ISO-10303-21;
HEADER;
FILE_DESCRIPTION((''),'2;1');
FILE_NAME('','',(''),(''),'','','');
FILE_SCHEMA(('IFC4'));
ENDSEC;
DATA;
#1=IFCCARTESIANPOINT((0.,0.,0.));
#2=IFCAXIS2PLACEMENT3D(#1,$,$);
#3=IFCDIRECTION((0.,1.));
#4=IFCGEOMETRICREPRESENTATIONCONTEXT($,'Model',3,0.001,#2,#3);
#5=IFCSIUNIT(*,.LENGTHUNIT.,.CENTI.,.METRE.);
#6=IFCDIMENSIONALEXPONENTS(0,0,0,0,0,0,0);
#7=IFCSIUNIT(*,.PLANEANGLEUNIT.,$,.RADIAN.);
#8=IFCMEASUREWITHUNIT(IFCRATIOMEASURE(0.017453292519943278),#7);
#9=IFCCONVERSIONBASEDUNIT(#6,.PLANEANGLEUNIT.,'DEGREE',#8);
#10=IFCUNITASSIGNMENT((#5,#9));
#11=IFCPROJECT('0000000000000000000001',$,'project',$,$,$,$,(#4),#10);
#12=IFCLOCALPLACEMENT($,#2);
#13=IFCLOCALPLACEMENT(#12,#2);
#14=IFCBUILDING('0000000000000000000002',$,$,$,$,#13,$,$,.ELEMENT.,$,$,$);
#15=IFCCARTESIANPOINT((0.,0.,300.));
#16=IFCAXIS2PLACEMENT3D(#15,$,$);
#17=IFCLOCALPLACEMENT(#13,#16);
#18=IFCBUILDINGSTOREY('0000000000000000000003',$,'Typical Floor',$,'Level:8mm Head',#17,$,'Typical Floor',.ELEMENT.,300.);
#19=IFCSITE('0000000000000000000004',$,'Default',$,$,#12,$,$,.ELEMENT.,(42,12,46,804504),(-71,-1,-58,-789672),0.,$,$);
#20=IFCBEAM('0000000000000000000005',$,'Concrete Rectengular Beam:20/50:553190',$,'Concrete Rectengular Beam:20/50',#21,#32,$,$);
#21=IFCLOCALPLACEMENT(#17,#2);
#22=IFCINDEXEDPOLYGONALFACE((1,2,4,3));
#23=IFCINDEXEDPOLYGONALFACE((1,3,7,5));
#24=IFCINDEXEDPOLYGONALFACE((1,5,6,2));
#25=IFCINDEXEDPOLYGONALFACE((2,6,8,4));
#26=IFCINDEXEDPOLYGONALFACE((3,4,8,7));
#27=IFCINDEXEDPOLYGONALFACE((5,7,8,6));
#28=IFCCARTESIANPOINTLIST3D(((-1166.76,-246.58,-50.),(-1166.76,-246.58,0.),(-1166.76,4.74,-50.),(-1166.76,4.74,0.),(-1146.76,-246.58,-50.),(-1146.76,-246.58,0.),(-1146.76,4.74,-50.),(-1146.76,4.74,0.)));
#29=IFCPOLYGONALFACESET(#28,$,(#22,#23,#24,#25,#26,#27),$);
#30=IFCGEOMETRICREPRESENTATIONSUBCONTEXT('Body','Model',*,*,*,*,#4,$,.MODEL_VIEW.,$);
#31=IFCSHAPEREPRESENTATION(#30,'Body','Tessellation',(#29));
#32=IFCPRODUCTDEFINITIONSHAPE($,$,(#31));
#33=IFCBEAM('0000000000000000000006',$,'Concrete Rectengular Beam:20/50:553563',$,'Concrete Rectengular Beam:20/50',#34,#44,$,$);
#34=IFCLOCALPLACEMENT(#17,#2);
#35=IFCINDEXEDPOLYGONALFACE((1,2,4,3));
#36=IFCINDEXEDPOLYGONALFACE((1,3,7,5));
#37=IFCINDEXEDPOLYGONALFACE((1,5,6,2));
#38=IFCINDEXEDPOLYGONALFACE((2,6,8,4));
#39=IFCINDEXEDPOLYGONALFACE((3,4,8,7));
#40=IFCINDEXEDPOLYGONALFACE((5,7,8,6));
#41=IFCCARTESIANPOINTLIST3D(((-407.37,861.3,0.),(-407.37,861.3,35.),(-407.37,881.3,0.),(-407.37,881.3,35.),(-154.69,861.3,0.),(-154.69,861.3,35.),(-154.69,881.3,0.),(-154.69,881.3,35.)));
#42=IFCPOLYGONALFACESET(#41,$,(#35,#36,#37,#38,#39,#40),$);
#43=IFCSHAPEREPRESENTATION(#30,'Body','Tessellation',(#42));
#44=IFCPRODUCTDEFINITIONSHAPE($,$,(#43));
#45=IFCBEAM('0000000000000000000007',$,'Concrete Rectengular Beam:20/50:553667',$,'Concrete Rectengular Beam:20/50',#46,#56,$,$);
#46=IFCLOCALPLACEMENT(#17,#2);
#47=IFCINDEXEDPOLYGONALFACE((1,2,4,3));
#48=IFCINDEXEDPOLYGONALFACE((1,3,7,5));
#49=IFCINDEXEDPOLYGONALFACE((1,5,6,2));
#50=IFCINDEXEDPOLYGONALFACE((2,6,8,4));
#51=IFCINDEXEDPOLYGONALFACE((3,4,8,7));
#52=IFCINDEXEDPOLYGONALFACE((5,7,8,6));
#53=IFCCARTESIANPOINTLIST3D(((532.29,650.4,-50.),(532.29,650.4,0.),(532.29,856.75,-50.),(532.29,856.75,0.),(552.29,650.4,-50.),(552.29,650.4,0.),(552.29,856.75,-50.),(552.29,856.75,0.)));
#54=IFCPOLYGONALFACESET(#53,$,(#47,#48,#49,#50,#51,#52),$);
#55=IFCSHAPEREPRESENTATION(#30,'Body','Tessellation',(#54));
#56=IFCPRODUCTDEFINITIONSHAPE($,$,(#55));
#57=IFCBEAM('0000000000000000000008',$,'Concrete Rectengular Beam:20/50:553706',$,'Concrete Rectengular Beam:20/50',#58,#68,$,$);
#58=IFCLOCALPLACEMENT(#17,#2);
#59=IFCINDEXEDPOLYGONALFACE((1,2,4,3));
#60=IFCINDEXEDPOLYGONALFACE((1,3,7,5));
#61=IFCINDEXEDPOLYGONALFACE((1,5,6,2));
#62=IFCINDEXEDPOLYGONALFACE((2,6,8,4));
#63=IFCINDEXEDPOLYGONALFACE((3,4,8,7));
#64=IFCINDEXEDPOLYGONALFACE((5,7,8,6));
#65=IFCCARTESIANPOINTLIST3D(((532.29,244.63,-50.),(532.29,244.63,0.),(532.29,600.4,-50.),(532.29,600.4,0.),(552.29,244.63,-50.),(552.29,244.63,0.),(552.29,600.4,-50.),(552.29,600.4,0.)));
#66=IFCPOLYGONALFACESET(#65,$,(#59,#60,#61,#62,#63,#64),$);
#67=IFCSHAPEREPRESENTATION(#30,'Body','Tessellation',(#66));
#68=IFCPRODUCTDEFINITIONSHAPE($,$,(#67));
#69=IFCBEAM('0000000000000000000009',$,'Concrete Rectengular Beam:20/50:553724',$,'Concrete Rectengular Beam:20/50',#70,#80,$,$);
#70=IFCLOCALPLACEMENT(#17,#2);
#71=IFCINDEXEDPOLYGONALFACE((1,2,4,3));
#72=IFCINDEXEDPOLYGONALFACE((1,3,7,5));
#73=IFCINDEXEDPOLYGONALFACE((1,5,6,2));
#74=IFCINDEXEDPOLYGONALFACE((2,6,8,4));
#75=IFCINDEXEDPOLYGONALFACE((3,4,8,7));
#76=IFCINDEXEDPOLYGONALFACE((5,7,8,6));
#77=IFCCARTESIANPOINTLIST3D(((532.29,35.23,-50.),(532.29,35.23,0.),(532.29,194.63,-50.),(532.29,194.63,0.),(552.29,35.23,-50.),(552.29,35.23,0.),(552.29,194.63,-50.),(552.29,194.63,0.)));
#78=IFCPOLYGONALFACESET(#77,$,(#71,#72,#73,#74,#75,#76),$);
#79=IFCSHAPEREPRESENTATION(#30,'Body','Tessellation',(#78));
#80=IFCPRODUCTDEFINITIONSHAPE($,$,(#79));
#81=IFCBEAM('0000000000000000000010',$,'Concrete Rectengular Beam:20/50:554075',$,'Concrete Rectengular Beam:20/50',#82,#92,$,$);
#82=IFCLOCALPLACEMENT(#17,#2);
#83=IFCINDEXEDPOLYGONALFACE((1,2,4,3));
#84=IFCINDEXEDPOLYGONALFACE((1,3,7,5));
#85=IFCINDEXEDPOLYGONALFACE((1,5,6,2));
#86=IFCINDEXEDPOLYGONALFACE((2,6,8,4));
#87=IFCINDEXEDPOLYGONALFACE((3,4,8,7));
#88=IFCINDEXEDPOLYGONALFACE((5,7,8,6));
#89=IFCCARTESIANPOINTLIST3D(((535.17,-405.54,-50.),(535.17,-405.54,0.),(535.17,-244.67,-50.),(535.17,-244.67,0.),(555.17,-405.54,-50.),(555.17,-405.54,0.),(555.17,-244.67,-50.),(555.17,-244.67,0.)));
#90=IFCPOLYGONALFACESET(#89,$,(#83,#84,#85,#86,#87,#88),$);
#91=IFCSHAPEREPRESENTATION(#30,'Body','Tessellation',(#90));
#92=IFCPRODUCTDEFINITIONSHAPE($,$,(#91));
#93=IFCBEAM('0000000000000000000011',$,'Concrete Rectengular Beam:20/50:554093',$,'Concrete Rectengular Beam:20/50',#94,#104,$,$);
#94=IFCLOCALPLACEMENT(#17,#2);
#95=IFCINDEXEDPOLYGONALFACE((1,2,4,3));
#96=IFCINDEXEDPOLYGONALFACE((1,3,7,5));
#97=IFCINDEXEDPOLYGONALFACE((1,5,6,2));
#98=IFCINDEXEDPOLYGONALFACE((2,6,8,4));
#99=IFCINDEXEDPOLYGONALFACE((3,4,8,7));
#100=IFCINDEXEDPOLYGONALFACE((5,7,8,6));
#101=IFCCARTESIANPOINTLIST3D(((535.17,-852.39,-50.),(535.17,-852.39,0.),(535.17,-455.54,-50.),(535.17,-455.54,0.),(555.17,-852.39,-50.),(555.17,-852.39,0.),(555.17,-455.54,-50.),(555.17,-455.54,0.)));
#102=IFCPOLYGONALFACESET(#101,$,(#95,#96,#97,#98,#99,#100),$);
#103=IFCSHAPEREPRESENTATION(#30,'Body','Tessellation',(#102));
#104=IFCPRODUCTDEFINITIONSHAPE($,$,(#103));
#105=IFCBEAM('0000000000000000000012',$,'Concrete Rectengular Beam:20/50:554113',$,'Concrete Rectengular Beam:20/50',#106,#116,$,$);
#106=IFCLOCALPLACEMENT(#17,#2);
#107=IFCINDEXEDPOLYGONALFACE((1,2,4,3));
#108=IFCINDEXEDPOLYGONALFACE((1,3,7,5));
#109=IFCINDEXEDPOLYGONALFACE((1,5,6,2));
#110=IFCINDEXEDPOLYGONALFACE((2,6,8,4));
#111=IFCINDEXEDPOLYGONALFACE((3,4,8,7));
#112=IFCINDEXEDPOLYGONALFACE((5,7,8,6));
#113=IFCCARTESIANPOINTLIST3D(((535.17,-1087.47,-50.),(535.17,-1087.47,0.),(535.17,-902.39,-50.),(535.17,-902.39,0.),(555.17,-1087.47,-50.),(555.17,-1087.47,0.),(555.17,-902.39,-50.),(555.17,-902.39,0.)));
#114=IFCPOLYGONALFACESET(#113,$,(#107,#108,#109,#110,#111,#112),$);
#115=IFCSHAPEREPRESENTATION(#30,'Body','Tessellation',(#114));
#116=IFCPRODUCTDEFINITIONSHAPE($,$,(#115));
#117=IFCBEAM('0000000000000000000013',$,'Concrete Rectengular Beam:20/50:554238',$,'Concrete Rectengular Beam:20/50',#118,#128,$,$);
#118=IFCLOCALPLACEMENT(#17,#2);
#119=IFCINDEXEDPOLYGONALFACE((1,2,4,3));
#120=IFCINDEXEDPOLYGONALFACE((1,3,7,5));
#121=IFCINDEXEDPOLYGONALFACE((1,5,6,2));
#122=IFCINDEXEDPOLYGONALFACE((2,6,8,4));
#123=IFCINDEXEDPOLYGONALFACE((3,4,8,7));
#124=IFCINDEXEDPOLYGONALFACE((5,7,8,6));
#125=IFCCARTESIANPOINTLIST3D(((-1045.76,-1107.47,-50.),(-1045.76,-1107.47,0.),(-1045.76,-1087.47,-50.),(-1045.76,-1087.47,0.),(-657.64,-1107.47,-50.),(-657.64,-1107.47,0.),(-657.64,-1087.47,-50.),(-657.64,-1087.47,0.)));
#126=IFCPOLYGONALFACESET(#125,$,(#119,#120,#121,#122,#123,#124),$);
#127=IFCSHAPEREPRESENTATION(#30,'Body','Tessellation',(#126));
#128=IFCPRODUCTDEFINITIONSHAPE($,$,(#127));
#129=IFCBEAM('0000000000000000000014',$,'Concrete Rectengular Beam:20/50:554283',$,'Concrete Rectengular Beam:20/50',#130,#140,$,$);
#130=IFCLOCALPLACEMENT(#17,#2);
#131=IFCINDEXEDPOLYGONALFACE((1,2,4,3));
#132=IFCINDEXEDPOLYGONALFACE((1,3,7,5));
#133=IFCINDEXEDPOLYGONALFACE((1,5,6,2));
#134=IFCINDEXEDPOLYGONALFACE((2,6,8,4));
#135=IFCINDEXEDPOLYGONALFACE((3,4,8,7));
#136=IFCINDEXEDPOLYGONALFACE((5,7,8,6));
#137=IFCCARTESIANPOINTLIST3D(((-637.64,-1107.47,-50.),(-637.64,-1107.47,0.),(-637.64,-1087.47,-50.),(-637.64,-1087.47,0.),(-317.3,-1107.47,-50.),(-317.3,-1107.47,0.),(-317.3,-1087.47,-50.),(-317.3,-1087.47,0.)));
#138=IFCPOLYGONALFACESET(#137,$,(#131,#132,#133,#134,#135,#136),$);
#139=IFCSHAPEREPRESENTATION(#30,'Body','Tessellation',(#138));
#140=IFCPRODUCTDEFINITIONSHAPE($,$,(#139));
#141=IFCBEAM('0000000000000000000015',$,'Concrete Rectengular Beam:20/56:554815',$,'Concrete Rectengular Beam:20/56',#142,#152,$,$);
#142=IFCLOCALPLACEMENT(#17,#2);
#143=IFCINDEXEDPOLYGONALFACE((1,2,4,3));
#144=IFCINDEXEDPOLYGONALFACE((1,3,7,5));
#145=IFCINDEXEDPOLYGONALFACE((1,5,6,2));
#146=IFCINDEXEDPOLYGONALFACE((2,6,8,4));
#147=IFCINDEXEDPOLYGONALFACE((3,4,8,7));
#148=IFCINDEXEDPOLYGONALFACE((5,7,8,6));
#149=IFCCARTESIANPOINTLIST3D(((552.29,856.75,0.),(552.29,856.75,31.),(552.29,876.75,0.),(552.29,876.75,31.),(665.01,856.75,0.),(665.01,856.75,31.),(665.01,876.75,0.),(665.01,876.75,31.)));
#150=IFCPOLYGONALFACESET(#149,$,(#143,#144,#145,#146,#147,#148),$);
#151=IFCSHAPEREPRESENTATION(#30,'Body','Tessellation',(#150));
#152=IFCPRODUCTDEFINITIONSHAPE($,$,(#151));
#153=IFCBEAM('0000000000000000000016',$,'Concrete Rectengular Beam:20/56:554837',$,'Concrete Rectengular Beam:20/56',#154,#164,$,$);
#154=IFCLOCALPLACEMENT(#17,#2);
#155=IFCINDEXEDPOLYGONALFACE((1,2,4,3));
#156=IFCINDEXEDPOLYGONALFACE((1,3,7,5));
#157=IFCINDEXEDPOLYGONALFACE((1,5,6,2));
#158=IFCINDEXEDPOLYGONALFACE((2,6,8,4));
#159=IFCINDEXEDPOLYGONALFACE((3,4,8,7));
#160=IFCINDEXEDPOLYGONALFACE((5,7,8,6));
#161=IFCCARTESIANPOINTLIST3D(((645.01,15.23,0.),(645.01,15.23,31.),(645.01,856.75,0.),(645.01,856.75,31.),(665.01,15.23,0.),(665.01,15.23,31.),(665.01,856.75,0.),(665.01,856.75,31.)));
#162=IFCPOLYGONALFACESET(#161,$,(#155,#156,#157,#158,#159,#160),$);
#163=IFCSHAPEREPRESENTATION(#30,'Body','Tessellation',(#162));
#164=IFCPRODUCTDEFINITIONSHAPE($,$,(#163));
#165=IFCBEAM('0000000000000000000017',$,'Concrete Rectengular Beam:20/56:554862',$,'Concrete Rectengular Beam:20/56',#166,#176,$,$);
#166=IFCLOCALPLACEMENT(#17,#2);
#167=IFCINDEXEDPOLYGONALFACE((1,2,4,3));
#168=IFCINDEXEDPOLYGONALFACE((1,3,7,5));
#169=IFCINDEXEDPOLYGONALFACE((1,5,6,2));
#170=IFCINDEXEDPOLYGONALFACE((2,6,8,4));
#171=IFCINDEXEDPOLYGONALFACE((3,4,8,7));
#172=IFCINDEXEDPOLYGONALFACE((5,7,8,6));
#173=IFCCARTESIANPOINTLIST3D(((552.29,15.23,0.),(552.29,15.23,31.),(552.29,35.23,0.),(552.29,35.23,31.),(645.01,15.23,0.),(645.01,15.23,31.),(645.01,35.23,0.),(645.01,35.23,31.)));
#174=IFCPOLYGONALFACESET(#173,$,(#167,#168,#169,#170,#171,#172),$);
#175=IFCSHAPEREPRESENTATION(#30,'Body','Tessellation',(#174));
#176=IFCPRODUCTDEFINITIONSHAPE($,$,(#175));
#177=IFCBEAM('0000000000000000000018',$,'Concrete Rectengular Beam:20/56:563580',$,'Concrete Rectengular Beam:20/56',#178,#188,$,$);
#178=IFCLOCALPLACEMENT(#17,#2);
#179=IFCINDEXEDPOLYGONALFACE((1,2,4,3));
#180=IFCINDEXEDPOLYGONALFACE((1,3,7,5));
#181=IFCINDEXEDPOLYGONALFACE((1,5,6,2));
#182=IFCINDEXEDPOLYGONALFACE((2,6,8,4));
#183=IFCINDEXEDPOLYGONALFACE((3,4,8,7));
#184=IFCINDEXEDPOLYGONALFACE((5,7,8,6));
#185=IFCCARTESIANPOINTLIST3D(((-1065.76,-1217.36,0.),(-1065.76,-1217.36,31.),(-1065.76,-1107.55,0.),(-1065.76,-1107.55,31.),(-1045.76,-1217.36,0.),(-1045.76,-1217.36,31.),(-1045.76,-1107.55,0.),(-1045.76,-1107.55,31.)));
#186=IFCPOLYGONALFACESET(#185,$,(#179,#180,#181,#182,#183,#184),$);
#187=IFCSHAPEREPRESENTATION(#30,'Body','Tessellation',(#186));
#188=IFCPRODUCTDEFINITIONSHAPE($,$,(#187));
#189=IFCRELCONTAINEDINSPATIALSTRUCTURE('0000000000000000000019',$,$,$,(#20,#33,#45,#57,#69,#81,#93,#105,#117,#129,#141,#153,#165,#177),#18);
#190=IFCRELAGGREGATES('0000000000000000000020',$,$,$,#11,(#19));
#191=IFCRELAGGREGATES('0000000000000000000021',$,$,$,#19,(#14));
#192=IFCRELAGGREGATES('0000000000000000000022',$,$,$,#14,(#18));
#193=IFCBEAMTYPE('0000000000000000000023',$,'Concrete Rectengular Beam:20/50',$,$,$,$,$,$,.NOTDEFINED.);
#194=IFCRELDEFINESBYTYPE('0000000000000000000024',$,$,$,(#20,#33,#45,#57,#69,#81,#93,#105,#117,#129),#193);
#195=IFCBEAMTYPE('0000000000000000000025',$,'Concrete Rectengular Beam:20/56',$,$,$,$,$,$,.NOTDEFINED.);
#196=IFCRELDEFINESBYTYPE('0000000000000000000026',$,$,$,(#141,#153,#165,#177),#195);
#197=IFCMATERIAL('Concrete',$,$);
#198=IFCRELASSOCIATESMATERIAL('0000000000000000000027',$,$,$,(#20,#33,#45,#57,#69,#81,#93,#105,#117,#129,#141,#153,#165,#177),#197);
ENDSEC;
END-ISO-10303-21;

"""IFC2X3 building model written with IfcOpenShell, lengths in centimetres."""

from ifc_helpers import new_model, entity, si_unit, converted_unit, direction, frame, frame_2d, origin, origin_2d_with_axis, place, context, subcontext, project, spatial, rectangle, extrude, material, type_object, element, save


model = new_model("IFC2X3")

# Units and contexts
model_context = context("Model", 3, precision=0.001, world=origin(), true_north=direction((0.0, 1.0)))
body_context = subcontext(model_context, "Body", "Model", "MODEL_VIEW")
ifc_project = project(units=[si_unit("LENGTHUNIT", "METRE", prefix="CENTI"), converted_unit("PLANEANGLEUNIT", "DEGREE", entity("IfcRatioMeasure", 0.017453292519943278), si_unit("PLANEANGLEUNIT", "RADIAN"), dimensions=[0, 0, 0, 0, 0, 0, 0])], contexts=[model_context])

# Site, building, storey
site_placement = place(None, origin())
site = spatial("IfcSite", under=ifc_project, at=site_placement, Name="Default", CompositionType="ELEMENT", RefLatitude=(42, 12, 46, 804504), RefLongitude=(-71, -1, -58, -789672), RefElevation=0.0)
building_placement = place(site_placement, origin())
building = spatial("IfcBuilding", under=site, at=building_placement, CompositionType="ELEMENT")
storey_placement = place(building_placement, frame((0.0, 0.0, 300.0)))
storey = spatial("IfcBuildingStorey", under=building, at=storey_placement, Name="Typical Floor", ObjectType="Level:8mm Head", LongName="Typical Floor", CompositionType="ELEMENT", Elevation=300.0)

# Beams
ifc_material = material(Name="Concrete")
beam_type_1 = type_object("IfcBeamType", Name="Concrete Rectengular Beam:20/50", PredefinedType="NOTDEFINED")
beam_1_placement = place(storey_placement, frame((-1156.76, -256.58, 0.0), z_axis=(0.0, 0.0, 1.0), x_axis=(0.0, 1.0, 0.0)))
element("IfcBeam", 1, at=beam_1_placement, inside=storey, type_object=beam_type_1, material=ifc_material, Name="Concrete Rectengular Beam:20/50:553190", ObjectType="Concrete Rectengular Beam:20/50", context=body_context, shape_type="SweptSolid", body=[
    extrude(rectangle(XDim=50.0, YDim=20.0, at=frame_2d((0.0, 0.0), x_axis=(1.0, 0.0))), frame((10.0, 0.0, -25.0), z_axis=(1.0, 0.0, 0.0), x_axis=(0.0, 0.0, -1.0)), (0.0, 0.0, 1.0), 251.32),
])
beam_2_placement = place(storey_placement, frame((-407.37, 871.3, 0.0)))
element("IfcBeam", 2, at=beam_2_placement, inside=storey, type_object=beam_type_1, material=ifc_material, Name="Concrete Rectengular Beam:20/50:553563", ObjectType="Concrete Rectengular Beam:20/50", context=body_context, shape_type="SweptSolid", body=[
    extrude(rectangle(XDim=35.0, YDim=20.0, at=frame_2d((0.0, 0.0), x_axis=(1.0, 0.0))), frame((0.0, 0.0, 17.5), z_axis=(1.0, 0.0, 0.0), x_axis=(0.0, 0.0, -1.0)), (0.0, 0.0, 1.0), 252.68),
])
beam_3_placement = place(storey_placement, frame((542.29, 625.4, 0.0), z_axis=(0.0, 0.0, 1.0), x_axis=(0.0, 1.0, 0.0)))
element("IfcBeam", 3, at=beam_3_placement, inside=storey, type_object=beam_type_1, material=ifc_material, Name="Concrete Rectengular Beam:20/50:553667", ObjectType="Concrete Rectengular Beam:20/50", context=body_context, shape_type="SweptSolid", body=[
    extrude(rectangle(XDim=50.0, YDim=20.0, at=origin_2d_with_axis()), frame((25.0, 0.0, -25.0), z_axis=(1.0, 0.0, 0.0), x_axis=(0.0, 0.0, -1.0)), (0.0, 0.0, 1.0), 206.35),
])
beam_4_placement = place(storey_placement, frame((542.29, 625.4, 0.0), z_axis=(0.0, 0.0, 1.0), x_axis=(0.0, -1.0, 0.0)))
element("IfcBeam", 4, at=beam_4_placement, inside=storey, type_object=beam_type_1, material=ifc_material, Name="Concrete Rectengular Beam:20/50:553706", ObjectType="Concrete Rectengular Beam:20/50", context=body_context, shape_type="SweptSolid", body=[
    extrude(rectangle(XDim=50.0, YDim=20.0, at=origin_2d_with_axis()), frame((25.0, 0.0, -25.0), z_axis=(1.0, 0.0, 0.0), x_axis=(0.0, 0.0, -1.0)), (0.0, 0.0, 1.0), 355.77),
])
beam_5_placement = place(storey_placement, frame((542.29, 219.63, 0.0), z_axis=(0.0, 0.0, 1.0), x_axis=(0.0, -1.0, 0.0)))
element("IfcBeam", 5, at=beam_5_placement, inside=storey, type_object=beam_type_1, material=ifc_material, Name="Concrete Rectengular Beam:20/50:553724", ObjectType="Concrete Rectengular Beam:20/50", context=body_context, shape_type="SweptSolid", body=[
    extrude(rectangle(XDim=50.0, YDim=20.0, at=frame_2d((0.0, 0.0), x_axis=(1.0, 0.0))), frame((25.0, 0.0, -25.0), z_axis=(1.0, 0.0, 0.0), x_axis=(0.0, 0.0, -1.0)), (0.0, 0.0, 1.0), 159.4),
])
beam_6_placement = place(storey_placement, frame((545.17, -234.67, 0.0), z_axis=(0.0, 0.0, 1.0), x_axis=(0.0, -1.0, 0.0)))
element("IfcBeam", 6, at=beam_6_placement, inside=storey, type_object=beam_type_1, material=ifc_material, Name="Concrete Rectengular Beam:20/50:554075", ObjectType="Concrete Rectengular Beam:20/50", context=body_context, shape_type="SweptSolid", body=[
    extrude(rectangle(XDim=50.0, YDim=20.0, at=origin_2d_with_axis()), frame((10.0, 0.0, -25.0), z_axis=(1.0, 0.0, 0.0), x_axis=(0.0, 0.0, -1.0)), (0.0, 0.0, 1.0), 160.87),
])
beam_7_placement = place(storey_placement, frame((545.17, -430.54, 0.0), z_axis=(0.0, 0.0, 1.0), x_axis=(0.0, -1.0, 0.0)))
element("IfcBeam", 7, at=beam_7_placement, inside=storey, type_object=beam_type_1, material=ifc_material, Name="Concrete Rectengular Beam:20/50:554093", ObjectType="Concrete Rectengular Beam:20/50", context=body_context, shape_type="SweptSolid", body=[
    extrude(rectangle(XDim=50.0, YDim=20.0, at=frame_2d((0.0, 0.0), x_axis=(1.0, 0.0))), frame((25.0, 0.0, -25.0), z_axis=(1.0, 0.0, 0.0), x_axis=(0.0, 0.0, -1.0)), (0.0, 0.0, 1.0), 396.84),
])
beam_8_placement = place(storey_placement, frame((545.17, -877.39, 0.0), z_axis=(0.0, 0.0, 1.0), x_axis=(0.0, -1.0, 0.0)))
element("IfcBeam", 8, at=beam_8_placement, inside=storey, type_object=beam_type_1, material=ifc_material, Name="Concrete Rectengular Beam:20/50:554113", ObjectType="Concrete Rectengular Beam:20/50", context=body_context, shape_type="SweptSolid", body=[
    extrude(rectangle(XDim=50.0, YDim=20.0, at=origin_2d_with_axis()), frame((25.0, 0.0, -25.0), z_axis=(1.0, 0.0, 0.0), x_axis=(0.0, 0.0, -1.0)), (0.0, 0.0, 1.0), 185.08),
])
beam_9_placement = place(storey_placement, frame((-647.64, -1097.47, 0.0), z_axis=(0.0, 0.0, 1.0), x_axis=(-1.0, 0.0, 0.0)))
element("IfcBeam", 9, at=beam_9_placement, inside=storey, type_object=beam_type_1, material=ifc_material, Name="Concrete Rectengular Beam:20/50:554238", ObjectType="Concrete Rectengular Beam:20/50", context=body_context, shape_type="SweptSolid", body=[
    extrude(rectangle(XDim=50.0, YDim=20.0, at=frame_2d((0.0, 0.0), x_axis=(1.0, 0.0))), frame((10.0, 0.0, -25.0), z_axis=(1.0, 0.0, 0.0), x_axis=(0.0, 0.0, -1.0)), (0.0, 0.0, 1.0), 388.12),
])
beam_10_placement = place(storey_placement, frame((-647.64, -1097.47, 0.0)))
element("IfcBeam", 10, at=beam_10_placement, inside=storey, type_object=beam_type_1, material=ifc_material, Name="Concrete Rectengular Beam:20/50:554283", ObjectType="Concrete Rectengular Beam:20/50", context=body_context, shape_type="SweptSolid", body=[
    extrude(rectangle(XDim=50.0, YDim=20.0, at=frame_2d((0.0, 0.0), x_axis=(1.0, 0.0))), frame((10.0, 0.0, -25.0), z_axis=(1.0, 0.0, 0.0), x_axis=(0.0, 0.0, -1.0)), (0.0, 0.0, 1.0), 320.35),
])
beam_type_2 = type_object("IfcBeamType", Name="Concrete Rectengular Beam:20/56", PredefinedType="NOTDEFINED")
beam_11_placement = place(storey_placement, frame((552.29, 866.75, 0.0)))
element("IfcBeam", 11, at=beam_11_placement, inside=storey, type_object=beam_type_2, material=ifc_material, Name="Concrete Rectengular Beam:20/56:554815", ObjectType="Concrete Rectengular Beam:20/56", context=body_context, shape_type="SweptSolid", body=[
    extrude(rectangle(XDim=31.0, YDim=20.0, at=frame_2d((0.0, 0.0), x_axis=(1.0, 0.0))), frame((0.0, 0.0, 15.5), z_axis=(1.0, 0.0, 0.0), x_axis=(0.0, 0.0, -1.0)), (0.0, 0.0, 1.0), 112.73),
])
beam_12_placement = place(storey_placement, frame((655.01, 866.75, 0.0), z_axis=(0.0, 0.0, 1.0), x_axis=(0.0, -1.0, 0.0)))
element("IfcBeam", 12, at=beam_12_placement, inside=storey, type_object=beam_type_2, material=ifc_material, Name="Concrete Rectengular Beam:20/56:554837", ObjectType="Concrete Rectengular Beam:20/56", context=body_context, shape_type="SweptSolid", body=[
    extrude(rectangle(XDim=31.0, YDim=20.0, at=frame_2d((0.0, 0.0), x_axis=(1.0, 0.0))), frame((10.0, 0.0, 15.5), z_axis=(1.0, 0.0, 0.0), x_axis=(0.0, 0.0, -1.0)), (0.0, 0.0, 1.0), 841.51),
])
beam_13_placement = place(storey_placement, frame((655.01, 25.23, 0.0), z_axis=(0.0, 0.0, 1.0), x_axis=(-1.0, 0.0, 0.0)))
element("IfcBeam", 13, at=beam_13_placement, inside=storey, type_object=beam_type_2, material=ifc_material, Name="Concrete Rectengular Beam:20/56:554862", ObjectType="Concrete Rectengular Beam:20/56", context=body_context, shape_type="SweptSolid", body=[
    extrude(rectangle(XDim=31.0, YDim=20.0, at=frame_2d((0.0, 0.0), x_axis=(1.0, 0.0))), frame((10.0, 0.0, 15.5), z_axis=(1.0, 0.0, 0.0), x_axis=(0.0, 0.0, -1.0)), (0.0, 0.0, 1.0), 92.73),
])
beam_14_placement = place(storey_placement, frame((-1055.76, -1107.55, 0.0), z_axis=(0.0, 0.0, 1.0), x_axis=(0.0, -1.0, 0.0)))
element("IfcBeam", 14, at=beam_14_placement, inside=storey, type_object=beam_type_2, material=ifc_material, Name="Concrete Rectengular Beam:20/56:563580", ObjectType="Concrete Rectengular Beam:20/56", context=body_context, shape_type="SweptSolid", body=[
    extrude(rectangle(XDim=31.0, YDim=20.0, at=frame_2d((0.0, 0.0), x_axis=(1.0, 0.0))), frame((0.0, 0.0, 15.5), z_axis=(1.0, 0.0, 0.0), x_axis=(0.0, 0.0, -1.0)), (0.0, 0.0, 1.0), 109.81),
])

save(model, "model.ifc")
